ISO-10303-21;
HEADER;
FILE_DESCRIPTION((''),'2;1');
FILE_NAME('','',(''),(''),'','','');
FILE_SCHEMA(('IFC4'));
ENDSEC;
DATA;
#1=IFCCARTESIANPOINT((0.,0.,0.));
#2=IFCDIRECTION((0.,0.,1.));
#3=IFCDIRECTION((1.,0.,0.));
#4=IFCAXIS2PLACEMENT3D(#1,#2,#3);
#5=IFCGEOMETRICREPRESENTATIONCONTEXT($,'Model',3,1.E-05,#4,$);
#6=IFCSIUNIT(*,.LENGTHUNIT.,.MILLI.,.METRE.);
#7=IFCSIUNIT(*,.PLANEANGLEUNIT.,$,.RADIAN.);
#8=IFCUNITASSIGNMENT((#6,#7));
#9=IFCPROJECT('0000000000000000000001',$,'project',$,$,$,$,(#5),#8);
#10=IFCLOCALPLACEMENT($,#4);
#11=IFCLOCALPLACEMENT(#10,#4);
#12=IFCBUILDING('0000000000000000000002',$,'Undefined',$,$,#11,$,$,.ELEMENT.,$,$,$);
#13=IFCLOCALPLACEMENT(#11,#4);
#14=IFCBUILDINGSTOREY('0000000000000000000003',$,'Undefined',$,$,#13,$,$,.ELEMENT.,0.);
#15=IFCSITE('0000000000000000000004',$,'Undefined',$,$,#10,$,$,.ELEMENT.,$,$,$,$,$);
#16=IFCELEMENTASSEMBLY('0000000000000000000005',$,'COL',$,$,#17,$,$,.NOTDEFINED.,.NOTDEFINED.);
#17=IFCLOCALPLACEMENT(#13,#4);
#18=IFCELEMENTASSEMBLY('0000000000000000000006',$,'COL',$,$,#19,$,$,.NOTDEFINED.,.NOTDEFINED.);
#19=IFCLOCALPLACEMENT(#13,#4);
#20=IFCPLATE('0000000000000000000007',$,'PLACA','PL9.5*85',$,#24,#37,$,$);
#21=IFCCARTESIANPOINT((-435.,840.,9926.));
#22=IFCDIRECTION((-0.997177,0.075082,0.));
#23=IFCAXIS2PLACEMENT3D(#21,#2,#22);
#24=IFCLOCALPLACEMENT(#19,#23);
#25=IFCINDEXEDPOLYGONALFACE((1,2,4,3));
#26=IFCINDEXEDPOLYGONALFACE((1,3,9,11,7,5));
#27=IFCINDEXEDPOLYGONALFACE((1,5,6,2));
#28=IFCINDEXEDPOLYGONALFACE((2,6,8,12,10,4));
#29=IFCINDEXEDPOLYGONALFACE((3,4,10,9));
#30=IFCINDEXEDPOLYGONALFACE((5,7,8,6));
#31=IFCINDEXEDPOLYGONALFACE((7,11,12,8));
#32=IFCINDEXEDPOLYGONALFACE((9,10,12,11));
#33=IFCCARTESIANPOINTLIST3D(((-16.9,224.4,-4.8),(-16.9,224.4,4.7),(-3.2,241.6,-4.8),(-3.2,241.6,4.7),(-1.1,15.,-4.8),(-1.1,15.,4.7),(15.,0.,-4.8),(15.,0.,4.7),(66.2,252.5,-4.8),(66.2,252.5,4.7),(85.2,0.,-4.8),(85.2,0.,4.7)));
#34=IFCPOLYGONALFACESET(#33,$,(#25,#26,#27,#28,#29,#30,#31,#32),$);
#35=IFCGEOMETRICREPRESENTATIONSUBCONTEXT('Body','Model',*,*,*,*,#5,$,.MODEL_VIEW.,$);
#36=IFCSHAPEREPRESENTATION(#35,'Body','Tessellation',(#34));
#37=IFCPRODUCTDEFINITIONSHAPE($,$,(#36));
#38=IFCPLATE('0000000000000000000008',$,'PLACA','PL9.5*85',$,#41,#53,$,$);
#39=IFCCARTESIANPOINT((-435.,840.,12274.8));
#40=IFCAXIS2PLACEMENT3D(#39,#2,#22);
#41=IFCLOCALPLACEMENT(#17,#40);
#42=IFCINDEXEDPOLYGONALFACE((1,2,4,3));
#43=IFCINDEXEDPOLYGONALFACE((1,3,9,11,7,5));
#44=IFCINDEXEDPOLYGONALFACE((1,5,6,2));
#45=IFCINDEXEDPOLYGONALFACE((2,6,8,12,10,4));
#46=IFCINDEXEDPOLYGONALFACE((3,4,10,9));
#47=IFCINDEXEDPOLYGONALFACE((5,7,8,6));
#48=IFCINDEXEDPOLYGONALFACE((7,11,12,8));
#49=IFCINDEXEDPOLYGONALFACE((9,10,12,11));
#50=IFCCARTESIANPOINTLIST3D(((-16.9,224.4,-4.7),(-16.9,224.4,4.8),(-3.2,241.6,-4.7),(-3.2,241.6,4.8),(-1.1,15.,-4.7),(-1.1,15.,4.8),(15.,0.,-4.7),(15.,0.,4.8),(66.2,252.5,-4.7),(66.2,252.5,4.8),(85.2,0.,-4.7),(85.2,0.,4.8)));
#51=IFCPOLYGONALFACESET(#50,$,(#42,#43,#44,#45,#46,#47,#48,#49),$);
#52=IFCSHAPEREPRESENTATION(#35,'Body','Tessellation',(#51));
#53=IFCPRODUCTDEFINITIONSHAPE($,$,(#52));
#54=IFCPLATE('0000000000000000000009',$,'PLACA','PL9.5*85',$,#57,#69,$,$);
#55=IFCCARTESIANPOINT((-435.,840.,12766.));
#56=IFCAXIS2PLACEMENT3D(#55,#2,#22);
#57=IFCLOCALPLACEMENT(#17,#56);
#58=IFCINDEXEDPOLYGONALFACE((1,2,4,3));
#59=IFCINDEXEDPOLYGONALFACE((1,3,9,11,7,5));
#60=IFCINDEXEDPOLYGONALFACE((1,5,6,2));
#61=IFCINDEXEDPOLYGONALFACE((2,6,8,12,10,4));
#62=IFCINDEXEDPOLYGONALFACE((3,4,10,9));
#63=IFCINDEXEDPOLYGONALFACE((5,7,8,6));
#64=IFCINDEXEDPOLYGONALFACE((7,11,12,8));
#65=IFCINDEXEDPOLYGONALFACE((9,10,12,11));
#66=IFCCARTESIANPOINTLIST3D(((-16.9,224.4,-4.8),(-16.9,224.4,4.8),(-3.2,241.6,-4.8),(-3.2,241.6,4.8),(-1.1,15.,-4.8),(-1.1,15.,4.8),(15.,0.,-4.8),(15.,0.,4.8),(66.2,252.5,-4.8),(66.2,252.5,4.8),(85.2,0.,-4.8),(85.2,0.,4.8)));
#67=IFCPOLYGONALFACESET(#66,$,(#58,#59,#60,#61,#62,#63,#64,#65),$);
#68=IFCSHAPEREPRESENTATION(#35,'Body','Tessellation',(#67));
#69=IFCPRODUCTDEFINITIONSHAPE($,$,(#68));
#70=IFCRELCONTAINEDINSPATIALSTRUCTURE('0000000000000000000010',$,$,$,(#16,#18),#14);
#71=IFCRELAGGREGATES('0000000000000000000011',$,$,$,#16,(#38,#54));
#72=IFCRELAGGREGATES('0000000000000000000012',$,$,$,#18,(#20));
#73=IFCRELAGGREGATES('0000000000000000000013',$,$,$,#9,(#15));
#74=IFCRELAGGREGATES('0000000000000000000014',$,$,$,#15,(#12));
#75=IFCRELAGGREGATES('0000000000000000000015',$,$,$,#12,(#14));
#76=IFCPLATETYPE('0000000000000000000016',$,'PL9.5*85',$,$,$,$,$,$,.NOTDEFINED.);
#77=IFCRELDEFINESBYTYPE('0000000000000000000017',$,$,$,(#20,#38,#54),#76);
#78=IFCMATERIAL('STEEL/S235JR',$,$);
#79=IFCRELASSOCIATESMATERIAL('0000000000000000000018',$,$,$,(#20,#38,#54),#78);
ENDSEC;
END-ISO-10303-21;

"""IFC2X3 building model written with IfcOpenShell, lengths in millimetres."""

from ifc_helpers import new_model, si_unit, frame, origin_with_axes, place, context, subcontext, project, spatial, polyline, outline, extrude, material, type_object, element, aggregate, save


model = new_model("IFC2X3")

# Units and contexts
model_context = context("Model", 3, precision=1e-05, world=origin_with_axes())
body_context = subcontext(model_context, "Body", "Model", "MODEL_VIEW")
ifc_project = project(units=[si_unit("LENGTHUNIT", "METRE", prefix="MILLI"), si_unit("PLANEANGLEUNIT", "RADIAN")], contexts=[model_context])

# Site, building, storey
site_placement = place(None, origin_with_axes())
site = spatial("IfcSite", under=ifc_project, at=site_placement, Name="Undefined", CompositionType="ELEMENT")
building_placement = place(site_placement, origin_with_axes())
building = spatial("IfcBuilding", under=site, at=building_placement, Name="Undefined", CompositionType="ELEMENT")
storey_placement = place(building_placement, origin_with_axes())
storey = spatial("IfcBuildingStorey", under=building, at=storey_placement, Name="Undefined", CompositionType="ELEMENT", Elevation=0.0)

# Shared definitions
ifc_material_1 = material(Name="STEEL/S235JR")

# Element assembly
assembly_1_placement = place(storey_placement, origin_with_axes())
assembly_1 = element("IfcElementAssembly", 1, at=assembly_1_placement, inside=storey, Name="COL", AssemblyPlace="NOTDEFINED", PredefinedType="NOTDEFINED")

# Element assembly, plate
assembly_2_placement = place(storey_placement, origin_with_axes())
assembly_2 = element("IfcElementAssembly", 2, at=assembly_2_placement, inside=storey, Name="COL", AssemblyPlace="NOTDEFINED", PredefinedType="NOTDEFINED")
plate_type_1 = type_object("IfcPlateType", Name="PL9.5*85", PredefinedType="NOTDEFINED")
plate_1_placement = place(assembly_2_placement, frame((-435.0, 840.0, 9926.0), z_axis=(0.0, 0.0, 1.0), x_axis=(-0.997177, 0.075082, 0.0)))
plate_1 = element("IfcPlate", 3, at=plate_1_placement, type_object=plate_type_1, material=ifc_material_1, Name="PLACA", Description="PL9.5*85", context=body_context, shape_type="SweptSolid", body=[
    extrude(outline(polyline([(-1.1, 15.0), (15.0, 0.0), (85.2, 0.0), (66.2, 252.5), (-3.2, 241.6), (-16.9, 224.4), (-1.1, 15.0)])), frame((0.0, 0.0, -4.7), z_axis=(0.0, 0.0, 1.0), x_axis=(1.0, 0.0, 0.0)), (0.0, 0.0, 1.0), 9.5),
])

# Plates
plate_2_placement = place(assembly_1_placement, frame((-435.0, 840.0, 12274.8), z_axis=(0.0, 0.0, 1.0), x_axis=(-0.997177, 0.075082, 0.0)))
plate_2 = element("IfcPlate", 4, at=plate_2_placement, type_object=plate_type_1, material=ifc_material_1, Name="PLACA", Description="PL9.5*85", context=body_context, shape_type="SweptSolid", body=[
    extrude(outline(polyline([(-1.1, 15.0), (15.0, 0.0), (85.2, 0.0), (66.2, 252.5), (-3.2, 241.6), (-16.9, 224.4), (-1.1, 15.0)])), frame((0.0, 0.0, -4.7), z_axis=(0.0, 0.0, 1.0), x_axis=(1.0, 0.0, 0.0)), (0.0, 0.0, 1.0), 9.5),
])
plate_3_placement = place(assembly_1_placement, frame((-435.0, 840.0, 12766.0), z_axis=(0.0, 0.0, 1.0), x_axis=(-0.997177, 0.075082, 0.0)))
plate_3 = element("IfcPlate", 5, at=plate_3_placement, type_object=plate_type_1, material=ifc_material_1, Name="PLACA", Description="PL9.5*85", context=body_context, shape_type="SweptSolid", body=[
    extrude(outline(polyline([(-1.1, 15.0), (15.0, 0.0), (85.2, 0.0), (66.2, 252.5), (-3.2, 241.6), (-16.9, 224.4), (-1.1, 15.0)])), frame((0.0, 0.0, -4.7), z_axis=(0.0, 0.0, 1.0), x_axis=(1.0, 0.0, 0.0)), (0.0, 0.0, 1.0), 9.5),
])
aggregate(assembly_1, [plate_2, plate_3])
aggregate(assembly_2, [plate_1])

save(model, "model.ifc")
